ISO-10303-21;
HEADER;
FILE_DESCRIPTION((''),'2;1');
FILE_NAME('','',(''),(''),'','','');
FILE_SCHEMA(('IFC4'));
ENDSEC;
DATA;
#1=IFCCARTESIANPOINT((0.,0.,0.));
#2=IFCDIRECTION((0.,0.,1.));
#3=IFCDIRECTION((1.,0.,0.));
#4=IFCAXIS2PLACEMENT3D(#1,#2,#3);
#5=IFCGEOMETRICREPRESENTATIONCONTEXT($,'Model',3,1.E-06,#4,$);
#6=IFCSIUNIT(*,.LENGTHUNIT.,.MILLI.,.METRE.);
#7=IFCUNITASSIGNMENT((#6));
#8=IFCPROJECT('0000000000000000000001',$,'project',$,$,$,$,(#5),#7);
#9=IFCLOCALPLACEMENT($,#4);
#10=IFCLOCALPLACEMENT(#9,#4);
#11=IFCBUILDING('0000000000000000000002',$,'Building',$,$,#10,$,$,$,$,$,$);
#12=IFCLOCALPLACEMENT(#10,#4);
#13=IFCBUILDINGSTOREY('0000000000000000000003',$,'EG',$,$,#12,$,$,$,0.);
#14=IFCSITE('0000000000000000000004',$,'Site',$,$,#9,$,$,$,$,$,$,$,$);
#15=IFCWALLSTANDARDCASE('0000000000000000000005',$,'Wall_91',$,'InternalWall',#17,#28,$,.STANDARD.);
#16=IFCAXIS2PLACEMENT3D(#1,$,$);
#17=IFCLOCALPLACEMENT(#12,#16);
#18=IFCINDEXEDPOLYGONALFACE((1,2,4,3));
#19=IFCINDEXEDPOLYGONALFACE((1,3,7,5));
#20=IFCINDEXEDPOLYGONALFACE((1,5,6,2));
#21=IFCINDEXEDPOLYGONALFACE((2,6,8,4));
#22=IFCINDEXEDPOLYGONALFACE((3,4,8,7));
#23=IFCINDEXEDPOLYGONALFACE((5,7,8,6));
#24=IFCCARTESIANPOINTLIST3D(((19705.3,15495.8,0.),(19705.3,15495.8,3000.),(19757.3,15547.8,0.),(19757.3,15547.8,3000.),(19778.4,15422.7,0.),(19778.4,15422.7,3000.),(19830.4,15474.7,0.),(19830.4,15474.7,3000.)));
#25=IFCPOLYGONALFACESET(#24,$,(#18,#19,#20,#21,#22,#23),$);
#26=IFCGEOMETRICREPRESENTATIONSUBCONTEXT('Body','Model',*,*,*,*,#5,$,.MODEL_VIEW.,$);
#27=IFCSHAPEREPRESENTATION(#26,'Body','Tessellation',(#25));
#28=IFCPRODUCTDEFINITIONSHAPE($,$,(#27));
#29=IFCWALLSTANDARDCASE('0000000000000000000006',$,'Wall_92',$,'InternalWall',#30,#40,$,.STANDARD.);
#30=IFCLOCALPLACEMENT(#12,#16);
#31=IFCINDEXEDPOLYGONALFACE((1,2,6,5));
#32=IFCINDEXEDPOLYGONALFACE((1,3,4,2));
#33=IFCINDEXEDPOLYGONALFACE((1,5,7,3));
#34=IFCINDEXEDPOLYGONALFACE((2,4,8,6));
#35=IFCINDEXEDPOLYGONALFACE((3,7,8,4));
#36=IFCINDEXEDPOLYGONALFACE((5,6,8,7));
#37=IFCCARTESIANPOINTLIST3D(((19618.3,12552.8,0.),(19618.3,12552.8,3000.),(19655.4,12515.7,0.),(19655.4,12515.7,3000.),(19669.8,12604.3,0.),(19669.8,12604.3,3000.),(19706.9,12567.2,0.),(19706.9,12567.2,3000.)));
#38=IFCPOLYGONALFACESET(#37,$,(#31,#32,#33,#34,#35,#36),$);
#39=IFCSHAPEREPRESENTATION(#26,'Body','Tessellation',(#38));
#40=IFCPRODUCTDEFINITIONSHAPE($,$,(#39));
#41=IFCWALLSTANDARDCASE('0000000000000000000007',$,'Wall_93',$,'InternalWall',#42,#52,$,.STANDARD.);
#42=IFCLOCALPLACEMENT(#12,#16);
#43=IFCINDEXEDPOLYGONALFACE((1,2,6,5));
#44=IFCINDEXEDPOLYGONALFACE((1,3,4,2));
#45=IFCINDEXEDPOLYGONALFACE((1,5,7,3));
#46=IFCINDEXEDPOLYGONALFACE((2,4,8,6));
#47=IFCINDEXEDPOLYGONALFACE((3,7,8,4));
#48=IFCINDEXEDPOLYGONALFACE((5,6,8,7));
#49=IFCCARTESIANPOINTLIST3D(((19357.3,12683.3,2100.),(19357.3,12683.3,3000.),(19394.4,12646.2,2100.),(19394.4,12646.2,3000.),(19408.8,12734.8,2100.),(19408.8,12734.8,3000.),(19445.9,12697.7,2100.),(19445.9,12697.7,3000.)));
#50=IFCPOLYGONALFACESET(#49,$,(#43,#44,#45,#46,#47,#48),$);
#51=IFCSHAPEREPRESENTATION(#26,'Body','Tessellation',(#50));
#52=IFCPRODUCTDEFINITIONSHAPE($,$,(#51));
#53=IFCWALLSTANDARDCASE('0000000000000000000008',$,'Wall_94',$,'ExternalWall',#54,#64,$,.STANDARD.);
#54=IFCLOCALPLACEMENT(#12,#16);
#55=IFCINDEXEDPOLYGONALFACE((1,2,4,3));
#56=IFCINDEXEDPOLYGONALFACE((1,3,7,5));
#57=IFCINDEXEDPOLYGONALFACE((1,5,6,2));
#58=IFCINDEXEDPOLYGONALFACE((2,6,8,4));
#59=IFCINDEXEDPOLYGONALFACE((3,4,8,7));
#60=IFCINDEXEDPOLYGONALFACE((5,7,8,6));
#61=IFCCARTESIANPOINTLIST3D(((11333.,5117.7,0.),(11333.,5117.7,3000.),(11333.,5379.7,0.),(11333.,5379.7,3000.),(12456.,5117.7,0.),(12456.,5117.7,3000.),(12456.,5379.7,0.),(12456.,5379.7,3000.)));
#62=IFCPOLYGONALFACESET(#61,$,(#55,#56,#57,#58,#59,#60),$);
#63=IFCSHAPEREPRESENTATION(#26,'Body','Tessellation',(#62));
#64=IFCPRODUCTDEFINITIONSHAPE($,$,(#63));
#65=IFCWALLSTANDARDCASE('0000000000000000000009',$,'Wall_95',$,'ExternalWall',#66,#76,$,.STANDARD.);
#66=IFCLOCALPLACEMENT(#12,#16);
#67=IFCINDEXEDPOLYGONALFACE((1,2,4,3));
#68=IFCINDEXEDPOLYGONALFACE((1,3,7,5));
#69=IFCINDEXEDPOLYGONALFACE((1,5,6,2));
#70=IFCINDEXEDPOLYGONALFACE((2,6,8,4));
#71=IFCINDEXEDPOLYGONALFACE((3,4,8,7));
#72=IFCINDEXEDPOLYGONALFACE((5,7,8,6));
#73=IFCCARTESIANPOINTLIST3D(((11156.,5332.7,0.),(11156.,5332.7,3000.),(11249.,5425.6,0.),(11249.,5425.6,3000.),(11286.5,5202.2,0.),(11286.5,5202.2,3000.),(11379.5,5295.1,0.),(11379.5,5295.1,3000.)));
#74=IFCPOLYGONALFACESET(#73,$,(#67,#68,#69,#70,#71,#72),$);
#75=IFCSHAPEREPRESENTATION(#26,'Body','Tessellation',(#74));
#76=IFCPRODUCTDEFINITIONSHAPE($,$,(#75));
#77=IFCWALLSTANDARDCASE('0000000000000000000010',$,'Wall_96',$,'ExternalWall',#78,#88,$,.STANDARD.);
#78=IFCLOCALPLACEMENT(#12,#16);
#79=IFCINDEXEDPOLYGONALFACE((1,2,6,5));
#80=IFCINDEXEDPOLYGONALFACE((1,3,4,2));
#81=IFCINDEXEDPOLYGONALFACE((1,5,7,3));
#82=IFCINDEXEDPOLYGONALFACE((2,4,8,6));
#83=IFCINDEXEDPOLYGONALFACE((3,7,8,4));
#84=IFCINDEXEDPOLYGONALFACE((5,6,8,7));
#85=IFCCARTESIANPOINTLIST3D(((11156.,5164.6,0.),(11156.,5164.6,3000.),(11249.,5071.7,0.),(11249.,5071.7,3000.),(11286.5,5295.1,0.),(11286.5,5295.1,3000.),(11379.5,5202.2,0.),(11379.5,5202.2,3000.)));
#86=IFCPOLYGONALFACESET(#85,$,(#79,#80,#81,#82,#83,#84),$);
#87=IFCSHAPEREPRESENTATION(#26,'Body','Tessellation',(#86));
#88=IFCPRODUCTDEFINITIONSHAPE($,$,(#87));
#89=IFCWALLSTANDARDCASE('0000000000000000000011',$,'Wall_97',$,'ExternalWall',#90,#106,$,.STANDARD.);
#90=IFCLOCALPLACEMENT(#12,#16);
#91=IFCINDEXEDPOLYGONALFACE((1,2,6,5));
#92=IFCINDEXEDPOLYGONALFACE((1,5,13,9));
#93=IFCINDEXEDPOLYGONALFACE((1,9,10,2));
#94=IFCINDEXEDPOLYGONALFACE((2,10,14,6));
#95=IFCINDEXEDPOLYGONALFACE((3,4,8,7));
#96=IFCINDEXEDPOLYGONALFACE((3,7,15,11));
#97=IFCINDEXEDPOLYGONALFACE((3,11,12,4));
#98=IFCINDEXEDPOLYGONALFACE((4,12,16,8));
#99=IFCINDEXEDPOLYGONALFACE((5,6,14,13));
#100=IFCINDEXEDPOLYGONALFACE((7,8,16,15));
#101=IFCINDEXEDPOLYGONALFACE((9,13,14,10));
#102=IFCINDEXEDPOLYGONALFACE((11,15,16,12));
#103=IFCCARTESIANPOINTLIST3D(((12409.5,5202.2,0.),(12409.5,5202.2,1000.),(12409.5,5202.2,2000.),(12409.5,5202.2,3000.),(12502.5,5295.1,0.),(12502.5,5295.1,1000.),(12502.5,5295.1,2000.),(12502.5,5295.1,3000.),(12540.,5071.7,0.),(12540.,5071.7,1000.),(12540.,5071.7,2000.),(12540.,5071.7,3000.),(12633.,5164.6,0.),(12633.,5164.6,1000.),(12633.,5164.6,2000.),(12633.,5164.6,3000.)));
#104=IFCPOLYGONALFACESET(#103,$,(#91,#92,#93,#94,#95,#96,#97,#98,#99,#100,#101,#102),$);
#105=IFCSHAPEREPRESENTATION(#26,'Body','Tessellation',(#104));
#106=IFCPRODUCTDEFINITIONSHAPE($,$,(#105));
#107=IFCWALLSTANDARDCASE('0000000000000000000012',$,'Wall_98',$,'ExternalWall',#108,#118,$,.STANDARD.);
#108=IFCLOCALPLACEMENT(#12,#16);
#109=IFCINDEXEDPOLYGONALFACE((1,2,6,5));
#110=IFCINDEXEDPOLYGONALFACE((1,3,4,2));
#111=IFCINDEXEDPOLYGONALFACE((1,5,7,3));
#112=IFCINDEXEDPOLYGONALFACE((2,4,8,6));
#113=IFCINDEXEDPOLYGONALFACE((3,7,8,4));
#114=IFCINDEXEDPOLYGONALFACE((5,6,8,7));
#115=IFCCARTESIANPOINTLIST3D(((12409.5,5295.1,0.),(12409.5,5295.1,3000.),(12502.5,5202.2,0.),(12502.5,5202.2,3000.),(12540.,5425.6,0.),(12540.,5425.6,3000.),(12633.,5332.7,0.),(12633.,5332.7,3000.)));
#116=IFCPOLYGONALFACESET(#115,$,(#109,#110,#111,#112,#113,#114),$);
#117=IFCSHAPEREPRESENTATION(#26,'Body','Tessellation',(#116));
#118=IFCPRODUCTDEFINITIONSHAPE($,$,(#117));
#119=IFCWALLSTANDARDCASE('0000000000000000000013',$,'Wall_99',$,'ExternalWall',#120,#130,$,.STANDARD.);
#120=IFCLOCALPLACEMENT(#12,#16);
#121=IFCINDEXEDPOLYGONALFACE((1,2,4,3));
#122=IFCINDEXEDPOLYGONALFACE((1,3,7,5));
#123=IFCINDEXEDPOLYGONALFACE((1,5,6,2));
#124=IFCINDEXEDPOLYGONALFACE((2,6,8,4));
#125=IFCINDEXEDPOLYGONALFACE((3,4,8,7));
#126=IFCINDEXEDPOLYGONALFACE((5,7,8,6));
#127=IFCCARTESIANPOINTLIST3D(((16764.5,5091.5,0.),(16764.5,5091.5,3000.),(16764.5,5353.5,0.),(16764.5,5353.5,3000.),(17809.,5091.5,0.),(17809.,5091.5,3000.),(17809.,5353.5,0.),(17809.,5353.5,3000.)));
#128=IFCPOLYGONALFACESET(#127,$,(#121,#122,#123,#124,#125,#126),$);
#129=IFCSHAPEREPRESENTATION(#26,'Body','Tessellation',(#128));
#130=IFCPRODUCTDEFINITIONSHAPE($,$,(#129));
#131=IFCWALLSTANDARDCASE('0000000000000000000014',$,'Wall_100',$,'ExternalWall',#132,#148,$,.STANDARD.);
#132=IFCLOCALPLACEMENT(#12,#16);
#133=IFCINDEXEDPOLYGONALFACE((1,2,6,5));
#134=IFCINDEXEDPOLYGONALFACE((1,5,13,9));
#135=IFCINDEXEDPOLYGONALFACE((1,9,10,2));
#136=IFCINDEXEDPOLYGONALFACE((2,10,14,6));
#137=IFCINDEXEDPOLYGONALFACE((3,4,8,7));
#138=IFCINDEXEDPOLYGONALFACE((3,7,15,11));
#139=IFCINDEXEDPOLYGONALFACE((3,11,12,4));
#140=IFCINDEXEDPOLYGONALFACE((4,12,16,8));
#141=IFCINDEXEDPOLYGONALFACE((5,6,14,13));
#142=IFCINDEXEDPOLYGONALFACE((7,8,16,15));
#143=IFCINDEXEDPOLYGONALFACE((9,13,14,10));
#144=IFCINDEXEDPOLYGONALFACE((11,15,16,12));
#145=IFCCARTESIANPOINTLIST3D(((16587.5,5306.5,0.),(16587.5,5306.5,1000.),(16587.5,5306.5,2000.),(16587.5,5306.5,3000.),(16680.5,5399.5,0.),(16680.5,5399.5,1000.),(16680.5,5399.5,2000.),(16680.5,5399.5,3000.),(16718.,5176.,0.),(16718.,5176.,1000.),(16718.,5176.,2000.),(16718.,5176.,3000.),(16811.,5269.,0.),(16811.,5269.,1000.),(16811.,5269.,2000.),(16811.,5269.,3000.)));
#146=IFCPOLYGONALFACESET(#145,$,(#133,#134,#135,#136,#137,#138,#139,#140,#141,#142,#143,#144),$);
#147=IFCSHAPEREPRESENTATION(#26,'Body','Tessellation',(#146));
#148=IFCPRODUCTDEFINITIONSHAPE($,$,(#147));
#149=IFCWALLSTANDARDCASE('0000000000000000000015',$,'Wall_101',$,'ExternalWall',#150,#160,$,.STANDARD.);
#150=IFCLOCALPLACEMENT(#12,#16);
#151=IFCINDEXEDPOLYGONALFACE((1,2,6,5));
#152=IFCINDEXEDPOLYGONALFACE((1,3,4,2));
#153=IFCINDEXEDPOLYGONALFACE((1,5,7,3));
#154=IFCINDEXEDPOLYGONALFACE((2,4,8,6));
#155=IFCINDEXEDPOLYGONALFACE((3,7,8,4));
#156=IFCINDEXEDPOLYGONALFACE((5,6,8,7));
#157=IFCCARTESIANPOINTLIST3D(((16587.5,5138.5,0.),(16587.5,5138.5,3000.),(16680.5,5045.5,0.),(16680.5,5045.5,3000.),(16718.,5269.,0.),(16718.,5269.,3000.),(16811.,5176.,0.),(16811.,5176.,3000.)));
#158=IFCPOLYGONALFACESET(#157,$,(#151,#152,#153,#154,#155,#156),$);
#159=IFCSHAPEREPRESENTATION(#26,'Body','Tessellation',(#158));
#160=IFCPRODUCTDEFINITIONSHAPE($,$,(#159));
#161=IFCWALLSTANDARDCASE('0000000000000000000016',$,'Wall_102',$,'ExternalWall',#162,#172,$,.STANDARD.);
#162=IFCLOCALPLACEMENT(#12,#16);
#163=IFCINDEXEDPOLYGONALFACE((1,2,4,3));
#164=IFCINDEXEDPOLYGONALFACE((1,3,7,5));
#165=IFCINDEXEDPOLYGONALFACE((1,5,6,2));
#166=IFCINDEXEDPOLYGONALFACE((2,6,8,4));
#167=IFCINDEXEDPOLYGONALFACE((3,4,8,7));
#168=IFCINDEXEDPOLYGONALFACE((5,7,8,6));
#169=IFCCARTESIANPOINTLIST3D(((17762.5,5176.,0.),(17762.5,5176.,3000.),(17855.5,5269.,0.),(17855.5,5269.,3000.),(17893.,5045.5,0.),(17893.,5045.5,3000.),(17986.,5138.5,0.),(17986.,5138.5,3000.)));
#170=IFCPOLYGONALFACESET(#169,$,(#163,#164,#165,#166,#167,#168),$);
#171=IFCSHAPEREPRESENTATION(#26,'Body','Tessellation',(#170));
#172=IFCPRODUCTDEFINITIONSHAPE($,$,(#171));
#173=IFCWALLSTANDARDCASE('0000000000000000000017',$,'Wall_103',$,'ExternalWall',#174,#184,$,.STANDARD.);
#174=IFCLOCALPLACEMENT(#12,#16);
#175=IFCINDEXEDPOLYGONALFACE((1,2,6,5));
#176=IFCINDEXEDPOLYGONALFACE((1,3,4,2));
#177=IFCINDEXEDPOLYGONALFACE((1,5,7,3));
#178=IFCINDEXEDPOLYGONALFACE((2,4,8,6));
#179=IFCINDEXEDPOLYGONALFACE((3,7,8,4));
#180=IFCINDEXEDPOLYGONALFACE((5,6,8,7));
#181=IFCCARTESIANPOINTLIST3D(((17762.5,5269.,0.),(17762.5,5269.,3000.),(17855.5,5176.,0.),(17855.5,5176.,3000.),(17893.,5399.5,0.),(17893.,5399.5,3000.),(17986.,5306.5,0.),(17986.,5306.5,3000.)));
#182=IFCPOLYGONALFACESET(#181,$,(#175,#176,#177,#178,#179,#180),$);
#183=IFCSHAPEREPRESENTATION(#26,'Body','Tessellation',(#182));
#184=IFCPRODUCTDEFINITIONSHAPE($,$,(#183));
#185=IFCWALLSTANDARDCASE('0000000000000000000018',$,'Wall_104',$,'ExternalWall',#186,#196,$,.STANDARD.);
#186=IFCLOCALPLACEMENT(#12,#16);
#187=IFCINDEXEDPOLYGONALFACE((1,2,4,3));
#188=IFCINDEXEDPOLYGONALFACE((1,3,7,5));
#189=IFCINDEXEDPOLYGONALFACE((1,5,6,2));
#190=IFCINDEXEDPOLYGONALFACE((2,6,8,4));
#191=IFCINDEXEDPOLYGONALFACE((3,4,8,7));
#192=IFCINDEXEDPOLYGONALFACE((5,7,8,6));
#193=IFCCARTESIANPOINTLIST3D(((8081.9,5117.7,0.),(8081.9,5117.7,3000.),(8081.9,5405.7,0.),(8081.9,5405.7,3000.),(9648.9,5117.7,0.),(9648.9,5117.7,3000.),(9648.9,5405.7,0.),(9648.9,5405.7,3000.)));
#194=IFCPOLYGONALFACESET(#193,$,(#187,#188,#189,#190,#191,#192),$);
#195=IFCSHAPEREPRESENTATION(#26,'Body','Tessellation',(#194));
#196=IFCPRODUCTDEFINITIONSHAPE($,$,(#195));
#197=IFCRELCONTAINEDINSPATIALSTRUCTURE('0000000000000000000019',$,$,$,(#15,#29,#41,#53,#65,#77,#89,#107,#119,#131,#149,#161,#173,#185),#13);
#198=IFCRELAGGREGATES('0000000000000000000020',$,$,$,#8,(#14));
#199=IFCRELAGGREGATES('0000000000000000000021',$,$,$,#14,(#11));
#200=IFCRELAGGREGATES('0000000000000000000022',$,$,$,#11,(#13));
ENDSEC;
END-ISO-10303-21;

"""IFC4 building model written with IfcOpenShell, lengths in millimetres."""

from ifc_helpers import new_model, si_unit, frame, origin_with_axes, place, context, subcontext, project, spatial, rectangle, extrude, element, save


model = new_model("IFC4")

# Units and contexts
model_context = context("Model", 3, precision=1e-06, world=origin_with_axes())
body_context = subcontext(model_context, "Body", "Model", "MODEL_VIEW")
ifc_project = project(units=[si_unit("LENGTHUNIT", "METRE", prefix="MILLI")], contexts=[model_context])

# Site, building, storey
site_placement = place(None, origin_with_axes())
site = spatial("IfcSite", under=ifc_project, at=site_placement, Name="Site")
building_placement = place(site_placement, origin_with_axes())
building = spatial("IfcBuilding", under=site, at=building_placement, Name="Building")
storey_placement = place(building_placement, origin_with_axes())
storey = spatial("IfcBuildingStorey", under=building, at=storey_placement, Name="EG", Elevation=0.0)

# Walls
wall_1_placement = place(storey_placement, origin_with_axes())
element("IfcWallStandardCase", 1, at=wall_1_placement, inside=storey, Name="Wall_91", ObjectType="InternalWall", PredefinedType="STANDARD", context=body_context, shape_type="SweptSolid", body=[
    extrude(rectangle(XDim=73.5, YDim=103.4), frame((19767.9, 15485.2, 0.0), z_axis=(0.0, 0.0, 1.0), x_axis=(-0.707107, -0.707107, 0.0)), (0.0, 0.0, 1.0), 3000.0),
])
wall_2_placement = place(storey_placement, origin_with_axes())
element("IfcWallStandardCase", 2, at=wall_2_placement, inside=storey, Name="Wall_92", ObjectType="InternalWall", PredefinedType="STANDARD", context=body_context, shape_type="SweptSolid", body=[
    extrude(rectangle(XDim=72.8, YDim=52.5), frame((19662.6, 12560.0, 0.0), z_axis=(0.0, 0.0, 1.0), x_axis=(0.707107, 0.707107, 0.0)), (0.0, 0.0, 1.0), 3000.0),
])

# Wall, opening
wall_3_placement = place(storey_placement, origin_with_axes())
wall_3 = element("IfcWallStandardCase", 3, at=wall_3_placement, inside=storey, Name="Wall_93", ObjectType="InternalWall", PredefinedType="STANDARD", context=body_context, shape_type="SweptSolid", body=[
    extrude(rectangle(XDim=72.8, YDim=52.5), frame((19401.6, 12690.5, 0.0), z_axis=(0.0, 0.0, 1.0), x_axis=(-0.707107, -0.707107, 0.0)), (0.0, 0.0, 1.0), 3000.0),
])
opening_1_placement = place(wall_3_placement, origin_with_axes())
element("IfcOpeningElement", 4, at=opening_1_placement, inside=storey, cuts=wall_3, context=body_context, shape_type="SweptSolid", body=[
    extrude(rectangle(XDim=450.0, YDim=52.5), frame((19401.6, 12690.5, 0.0), z_axis=(0.0, 0.0, 1.0), x_axis=(-0.707107, -0.707107, 0.0)), (0.0, 0.0, 1.0), 2100.0),
])

# Walls
wall_4_placement = place(storey_placement, origin_with_axes())
element("IfcWallStandardCase", 5, at=wall_4_placement, inside=storey, Name="Wall_94", ObjectType="ExternalWall", PredefinedType="STANDARD", context=body_context, shape_type="SweptSolid", body=[
    extrude(rectangle(XDim=1123.0, YDim=262.0), frame((11894.5, 5248.7, 0.0), z_axis=(0.0, 0.0, 1.0), x_axis=(1.0, 0.0, 0.0)), (0.0, 0.0, 1.0), 3000.0),
])
wall_5_placement = place(storey_placement, origin_with_axes())
element("IfcWallStandardCase", 6, at=wall_5_placement, inside=storey, Name="Wall_95", ObjectType="ExternalWall", PredefinedType="STANDARD", context=body_context, shape_type="SweptSolid", body=[
    extrude(rectangle(XDim=184.6, YDim=131.5), frame((11267.7, 5313.9, 0.0), z_axis=(0.0, 0.0, 1.0), x_axis=(0.707107, -0.707107, 0.0)), (0.0, 0.0, 1.0), 3000.0),
])
wall_6_placement = place(storey_placement, origin_with_axes())
element("IfcWallStandardCase", 7, at=wall_6_placement, inside=storey, Name="Wall_96", ObjectType="ExternalWall", PredefinedType="STANDARD", context=body_context, shape_type="SweptSolid", body=[
    extrude(rectangle(XDim=184.6, YDim=131.5), frame((11267.7, 5183.4, 0.0), z_axis=(0.0, 0.0, 1.0), x_axis=(-0.707107, -0.707107, 0.0)), (0.0, 0.0, 1.0), 3000.0),
])

# Wall, opening
wall_7_placement = place(storey_placement, origin_with_axes())
wall_7 = element("IfcWallStandardCase", 8, at=wall_7_placement, inside=storey, Name="Wall_97", ObjectType="ExternalWall", PredefinedType="STANDARD", context=body_context, shape_type="SweptSolid", body=[
    extrude(rectangle(XDim=184.6, YDim=131.5), frame((12521.2, 5183.4, 0.0), z_axis=(0.0, 0.0, 1.0), x_axis=(0.707107, -0.707107, 0.0)), (0.0, 0.0, 1.0), 3000.0),
])
opening_2_placement = place(wall_7_placement, origin_with_axes())
element("IfcOpeningElement", 9, at=opening_2_placement, inside=storey, cuts=wall_7, context=body_context, shape_type="SweptSolid", body=[
    extrude(rectangle(XDim=600.0, YDim=131.5), frame((12521.2, 5183.4, 1000.0), z_axis=(0.0, 0.0, 1.0), x_axis=(0.707107, -0.707107, 0.0)), (0.0, 0.0, 1.0), 1000.0),
])

# Walls
wall_8_placement = place(storey_placement, origin_with_axes())
element("IfcWallStandardCase", 10, at=wall_8_placement, inside=storey, Name="Wall_98", ObjectType="ExternalWall", PredefinedType="STANDARD", context=body_context, shape_type="SweptSolid", body=[
    extrude(rectangle(XDim=184.6, YDim=131.5), frame((12521.2, 5313.9, 0.0), z_axis=(0.0, 0.0, 1.0), x_axis=(0.707107, 0.707107, 0.0)), (0.0, 0.0, 1.0), 3000.0),
])
wall_9_placement = place(storey_placement, origin_with_axes())
element("IfcWallStandardCase", 11, at=wall_9_placement, inside=storey, Name="Wall_99", ObjectType="ExternalWall", PredefinedType="STANDARD", context=body_context, shape_type="SweptSolid", body=[
    extrude(rectangle(XDim=1044.5, YDim=262.0), frame((17286.7, 5222.5, 0.0), z_axis=(0.0, 0.0, 1.0), x_axis=(1.0, 0.0, 0.0)), (0.0, 0.0, 1.0), 3000.0),
])

# Wall, opening
wall_10_placement = place(storey_placement, origin_with_axes())
wall_10 = element("IfcWallStandardCase", 12, at=wall_10_placement, inside=storey, Name="Wall_100", ObjectType="ExternalWall", PredefinedType="STANDARD", context=body_context, shape_type="SweptSolid", body=[
    extrude(rectangle(XDim=184.6, YDim=131.5), frame((16699.2, 5287.8, 0.0), z_axis=(0.0, 0.0, 1.0), x_axis=(0.707107, -0.707107, 0.0)), (0.0, 0.0, 1.0), 3000.0),
])
opening_3_placement = place(wall_10_placement, origin_with_axes())
element("IfcOpeningElement", 13, at=opening_3_placement, inside=storey, cuts=wall_10, context=body_context, shape_type="SweptSolid", body=[
    extrude(rectangle(XDim=600.0, YDim=131.5), frame((16692.7, 5294.3, 1000.0), z_axis=(0.0, 0.0, 1.0), x_axis=(0.707107, -0.707107, 0.0)), (0.0, 0.0, 1.0), 1000.0),
])

# Walls
wall_11_placement = place(storey_placement, origin_with_axes())
element("IfcWallStandardCase", 14, at=wall_11_placement, inside=storey, Name="Wall_101", ObjectType="ExternalWall", PredefinedType="STANDARD", context=body_context, shape_type="SweptSolid", body=[
    extrude(rectangle(XDim=184.6, YDim=131.5), frame((16699.2, 5157.3, 0.0), z_axis=(0.0, 0.0, 1.0), x_axis=(-0.707107, -0.707107, 0.0)), (0.0, 0.0, 1.0), 3000.0),
])
wall_12_placement = place(storey_placement, origin_with_axes())
element("IfcWallStandardCase", 15, at=wall_12_placement, inside=storey, Name="Wall_102", ObjectType="ExternalWall", PredefinedType="STANDARD", context=body_context, shape_type="SweptSolid", body=[
    extrude(rectangle(XDim=184.6, YDim=131.5), frame((17874.2, 5157.3, 0.0), z_axis=(0.0, 0.0, 1.0), x_axis=(0.707107, -0.707107, 0.0)), (0.0, 0.0, 1.0), 3000.0),
])
wall_13_placement = place(storey_placement, origin_with_axes())
element("IfcWallStandardCase", 16, at=wall_13_placement, inside=storey, Name="Wall_103", ObjectType="ExternalWall", PredefinedType="STANDARD", context=body_context, shape_type="SweptSolid", body=[
    extrude(rectangle(XDim=184.6, YDim=131.5), frame((17874.2, 5287.8, 0.0), z_axis=(0.0, 0.0, 1.0), x_axis=(0.707107, 0.707107, 0.0)), (0.0, 0.0, 1.0), 3000.0),
])
wall_14_placement = place(storey_placement, origin_with_axes())
element("IfcWallStandardCase", 17, at=wall_14_placement, inside=storey, Name="Wall_104", ObjectType="ExternalWall", PredefinedType="STANDARD", context=body_context, shape_type="SweptSolid", body=[
    extrude(rectangle(XDim=1567.0, YDim=288.0), frame((8865.4, 5261.7, 0.0), z_axis=(0.0, 0.0, 1.0), x_axis=(-1.0, 0.0, 0.0)), (0.0, 0.0, 1.0), 3000.0),
])

save(model, "model.ifc")
